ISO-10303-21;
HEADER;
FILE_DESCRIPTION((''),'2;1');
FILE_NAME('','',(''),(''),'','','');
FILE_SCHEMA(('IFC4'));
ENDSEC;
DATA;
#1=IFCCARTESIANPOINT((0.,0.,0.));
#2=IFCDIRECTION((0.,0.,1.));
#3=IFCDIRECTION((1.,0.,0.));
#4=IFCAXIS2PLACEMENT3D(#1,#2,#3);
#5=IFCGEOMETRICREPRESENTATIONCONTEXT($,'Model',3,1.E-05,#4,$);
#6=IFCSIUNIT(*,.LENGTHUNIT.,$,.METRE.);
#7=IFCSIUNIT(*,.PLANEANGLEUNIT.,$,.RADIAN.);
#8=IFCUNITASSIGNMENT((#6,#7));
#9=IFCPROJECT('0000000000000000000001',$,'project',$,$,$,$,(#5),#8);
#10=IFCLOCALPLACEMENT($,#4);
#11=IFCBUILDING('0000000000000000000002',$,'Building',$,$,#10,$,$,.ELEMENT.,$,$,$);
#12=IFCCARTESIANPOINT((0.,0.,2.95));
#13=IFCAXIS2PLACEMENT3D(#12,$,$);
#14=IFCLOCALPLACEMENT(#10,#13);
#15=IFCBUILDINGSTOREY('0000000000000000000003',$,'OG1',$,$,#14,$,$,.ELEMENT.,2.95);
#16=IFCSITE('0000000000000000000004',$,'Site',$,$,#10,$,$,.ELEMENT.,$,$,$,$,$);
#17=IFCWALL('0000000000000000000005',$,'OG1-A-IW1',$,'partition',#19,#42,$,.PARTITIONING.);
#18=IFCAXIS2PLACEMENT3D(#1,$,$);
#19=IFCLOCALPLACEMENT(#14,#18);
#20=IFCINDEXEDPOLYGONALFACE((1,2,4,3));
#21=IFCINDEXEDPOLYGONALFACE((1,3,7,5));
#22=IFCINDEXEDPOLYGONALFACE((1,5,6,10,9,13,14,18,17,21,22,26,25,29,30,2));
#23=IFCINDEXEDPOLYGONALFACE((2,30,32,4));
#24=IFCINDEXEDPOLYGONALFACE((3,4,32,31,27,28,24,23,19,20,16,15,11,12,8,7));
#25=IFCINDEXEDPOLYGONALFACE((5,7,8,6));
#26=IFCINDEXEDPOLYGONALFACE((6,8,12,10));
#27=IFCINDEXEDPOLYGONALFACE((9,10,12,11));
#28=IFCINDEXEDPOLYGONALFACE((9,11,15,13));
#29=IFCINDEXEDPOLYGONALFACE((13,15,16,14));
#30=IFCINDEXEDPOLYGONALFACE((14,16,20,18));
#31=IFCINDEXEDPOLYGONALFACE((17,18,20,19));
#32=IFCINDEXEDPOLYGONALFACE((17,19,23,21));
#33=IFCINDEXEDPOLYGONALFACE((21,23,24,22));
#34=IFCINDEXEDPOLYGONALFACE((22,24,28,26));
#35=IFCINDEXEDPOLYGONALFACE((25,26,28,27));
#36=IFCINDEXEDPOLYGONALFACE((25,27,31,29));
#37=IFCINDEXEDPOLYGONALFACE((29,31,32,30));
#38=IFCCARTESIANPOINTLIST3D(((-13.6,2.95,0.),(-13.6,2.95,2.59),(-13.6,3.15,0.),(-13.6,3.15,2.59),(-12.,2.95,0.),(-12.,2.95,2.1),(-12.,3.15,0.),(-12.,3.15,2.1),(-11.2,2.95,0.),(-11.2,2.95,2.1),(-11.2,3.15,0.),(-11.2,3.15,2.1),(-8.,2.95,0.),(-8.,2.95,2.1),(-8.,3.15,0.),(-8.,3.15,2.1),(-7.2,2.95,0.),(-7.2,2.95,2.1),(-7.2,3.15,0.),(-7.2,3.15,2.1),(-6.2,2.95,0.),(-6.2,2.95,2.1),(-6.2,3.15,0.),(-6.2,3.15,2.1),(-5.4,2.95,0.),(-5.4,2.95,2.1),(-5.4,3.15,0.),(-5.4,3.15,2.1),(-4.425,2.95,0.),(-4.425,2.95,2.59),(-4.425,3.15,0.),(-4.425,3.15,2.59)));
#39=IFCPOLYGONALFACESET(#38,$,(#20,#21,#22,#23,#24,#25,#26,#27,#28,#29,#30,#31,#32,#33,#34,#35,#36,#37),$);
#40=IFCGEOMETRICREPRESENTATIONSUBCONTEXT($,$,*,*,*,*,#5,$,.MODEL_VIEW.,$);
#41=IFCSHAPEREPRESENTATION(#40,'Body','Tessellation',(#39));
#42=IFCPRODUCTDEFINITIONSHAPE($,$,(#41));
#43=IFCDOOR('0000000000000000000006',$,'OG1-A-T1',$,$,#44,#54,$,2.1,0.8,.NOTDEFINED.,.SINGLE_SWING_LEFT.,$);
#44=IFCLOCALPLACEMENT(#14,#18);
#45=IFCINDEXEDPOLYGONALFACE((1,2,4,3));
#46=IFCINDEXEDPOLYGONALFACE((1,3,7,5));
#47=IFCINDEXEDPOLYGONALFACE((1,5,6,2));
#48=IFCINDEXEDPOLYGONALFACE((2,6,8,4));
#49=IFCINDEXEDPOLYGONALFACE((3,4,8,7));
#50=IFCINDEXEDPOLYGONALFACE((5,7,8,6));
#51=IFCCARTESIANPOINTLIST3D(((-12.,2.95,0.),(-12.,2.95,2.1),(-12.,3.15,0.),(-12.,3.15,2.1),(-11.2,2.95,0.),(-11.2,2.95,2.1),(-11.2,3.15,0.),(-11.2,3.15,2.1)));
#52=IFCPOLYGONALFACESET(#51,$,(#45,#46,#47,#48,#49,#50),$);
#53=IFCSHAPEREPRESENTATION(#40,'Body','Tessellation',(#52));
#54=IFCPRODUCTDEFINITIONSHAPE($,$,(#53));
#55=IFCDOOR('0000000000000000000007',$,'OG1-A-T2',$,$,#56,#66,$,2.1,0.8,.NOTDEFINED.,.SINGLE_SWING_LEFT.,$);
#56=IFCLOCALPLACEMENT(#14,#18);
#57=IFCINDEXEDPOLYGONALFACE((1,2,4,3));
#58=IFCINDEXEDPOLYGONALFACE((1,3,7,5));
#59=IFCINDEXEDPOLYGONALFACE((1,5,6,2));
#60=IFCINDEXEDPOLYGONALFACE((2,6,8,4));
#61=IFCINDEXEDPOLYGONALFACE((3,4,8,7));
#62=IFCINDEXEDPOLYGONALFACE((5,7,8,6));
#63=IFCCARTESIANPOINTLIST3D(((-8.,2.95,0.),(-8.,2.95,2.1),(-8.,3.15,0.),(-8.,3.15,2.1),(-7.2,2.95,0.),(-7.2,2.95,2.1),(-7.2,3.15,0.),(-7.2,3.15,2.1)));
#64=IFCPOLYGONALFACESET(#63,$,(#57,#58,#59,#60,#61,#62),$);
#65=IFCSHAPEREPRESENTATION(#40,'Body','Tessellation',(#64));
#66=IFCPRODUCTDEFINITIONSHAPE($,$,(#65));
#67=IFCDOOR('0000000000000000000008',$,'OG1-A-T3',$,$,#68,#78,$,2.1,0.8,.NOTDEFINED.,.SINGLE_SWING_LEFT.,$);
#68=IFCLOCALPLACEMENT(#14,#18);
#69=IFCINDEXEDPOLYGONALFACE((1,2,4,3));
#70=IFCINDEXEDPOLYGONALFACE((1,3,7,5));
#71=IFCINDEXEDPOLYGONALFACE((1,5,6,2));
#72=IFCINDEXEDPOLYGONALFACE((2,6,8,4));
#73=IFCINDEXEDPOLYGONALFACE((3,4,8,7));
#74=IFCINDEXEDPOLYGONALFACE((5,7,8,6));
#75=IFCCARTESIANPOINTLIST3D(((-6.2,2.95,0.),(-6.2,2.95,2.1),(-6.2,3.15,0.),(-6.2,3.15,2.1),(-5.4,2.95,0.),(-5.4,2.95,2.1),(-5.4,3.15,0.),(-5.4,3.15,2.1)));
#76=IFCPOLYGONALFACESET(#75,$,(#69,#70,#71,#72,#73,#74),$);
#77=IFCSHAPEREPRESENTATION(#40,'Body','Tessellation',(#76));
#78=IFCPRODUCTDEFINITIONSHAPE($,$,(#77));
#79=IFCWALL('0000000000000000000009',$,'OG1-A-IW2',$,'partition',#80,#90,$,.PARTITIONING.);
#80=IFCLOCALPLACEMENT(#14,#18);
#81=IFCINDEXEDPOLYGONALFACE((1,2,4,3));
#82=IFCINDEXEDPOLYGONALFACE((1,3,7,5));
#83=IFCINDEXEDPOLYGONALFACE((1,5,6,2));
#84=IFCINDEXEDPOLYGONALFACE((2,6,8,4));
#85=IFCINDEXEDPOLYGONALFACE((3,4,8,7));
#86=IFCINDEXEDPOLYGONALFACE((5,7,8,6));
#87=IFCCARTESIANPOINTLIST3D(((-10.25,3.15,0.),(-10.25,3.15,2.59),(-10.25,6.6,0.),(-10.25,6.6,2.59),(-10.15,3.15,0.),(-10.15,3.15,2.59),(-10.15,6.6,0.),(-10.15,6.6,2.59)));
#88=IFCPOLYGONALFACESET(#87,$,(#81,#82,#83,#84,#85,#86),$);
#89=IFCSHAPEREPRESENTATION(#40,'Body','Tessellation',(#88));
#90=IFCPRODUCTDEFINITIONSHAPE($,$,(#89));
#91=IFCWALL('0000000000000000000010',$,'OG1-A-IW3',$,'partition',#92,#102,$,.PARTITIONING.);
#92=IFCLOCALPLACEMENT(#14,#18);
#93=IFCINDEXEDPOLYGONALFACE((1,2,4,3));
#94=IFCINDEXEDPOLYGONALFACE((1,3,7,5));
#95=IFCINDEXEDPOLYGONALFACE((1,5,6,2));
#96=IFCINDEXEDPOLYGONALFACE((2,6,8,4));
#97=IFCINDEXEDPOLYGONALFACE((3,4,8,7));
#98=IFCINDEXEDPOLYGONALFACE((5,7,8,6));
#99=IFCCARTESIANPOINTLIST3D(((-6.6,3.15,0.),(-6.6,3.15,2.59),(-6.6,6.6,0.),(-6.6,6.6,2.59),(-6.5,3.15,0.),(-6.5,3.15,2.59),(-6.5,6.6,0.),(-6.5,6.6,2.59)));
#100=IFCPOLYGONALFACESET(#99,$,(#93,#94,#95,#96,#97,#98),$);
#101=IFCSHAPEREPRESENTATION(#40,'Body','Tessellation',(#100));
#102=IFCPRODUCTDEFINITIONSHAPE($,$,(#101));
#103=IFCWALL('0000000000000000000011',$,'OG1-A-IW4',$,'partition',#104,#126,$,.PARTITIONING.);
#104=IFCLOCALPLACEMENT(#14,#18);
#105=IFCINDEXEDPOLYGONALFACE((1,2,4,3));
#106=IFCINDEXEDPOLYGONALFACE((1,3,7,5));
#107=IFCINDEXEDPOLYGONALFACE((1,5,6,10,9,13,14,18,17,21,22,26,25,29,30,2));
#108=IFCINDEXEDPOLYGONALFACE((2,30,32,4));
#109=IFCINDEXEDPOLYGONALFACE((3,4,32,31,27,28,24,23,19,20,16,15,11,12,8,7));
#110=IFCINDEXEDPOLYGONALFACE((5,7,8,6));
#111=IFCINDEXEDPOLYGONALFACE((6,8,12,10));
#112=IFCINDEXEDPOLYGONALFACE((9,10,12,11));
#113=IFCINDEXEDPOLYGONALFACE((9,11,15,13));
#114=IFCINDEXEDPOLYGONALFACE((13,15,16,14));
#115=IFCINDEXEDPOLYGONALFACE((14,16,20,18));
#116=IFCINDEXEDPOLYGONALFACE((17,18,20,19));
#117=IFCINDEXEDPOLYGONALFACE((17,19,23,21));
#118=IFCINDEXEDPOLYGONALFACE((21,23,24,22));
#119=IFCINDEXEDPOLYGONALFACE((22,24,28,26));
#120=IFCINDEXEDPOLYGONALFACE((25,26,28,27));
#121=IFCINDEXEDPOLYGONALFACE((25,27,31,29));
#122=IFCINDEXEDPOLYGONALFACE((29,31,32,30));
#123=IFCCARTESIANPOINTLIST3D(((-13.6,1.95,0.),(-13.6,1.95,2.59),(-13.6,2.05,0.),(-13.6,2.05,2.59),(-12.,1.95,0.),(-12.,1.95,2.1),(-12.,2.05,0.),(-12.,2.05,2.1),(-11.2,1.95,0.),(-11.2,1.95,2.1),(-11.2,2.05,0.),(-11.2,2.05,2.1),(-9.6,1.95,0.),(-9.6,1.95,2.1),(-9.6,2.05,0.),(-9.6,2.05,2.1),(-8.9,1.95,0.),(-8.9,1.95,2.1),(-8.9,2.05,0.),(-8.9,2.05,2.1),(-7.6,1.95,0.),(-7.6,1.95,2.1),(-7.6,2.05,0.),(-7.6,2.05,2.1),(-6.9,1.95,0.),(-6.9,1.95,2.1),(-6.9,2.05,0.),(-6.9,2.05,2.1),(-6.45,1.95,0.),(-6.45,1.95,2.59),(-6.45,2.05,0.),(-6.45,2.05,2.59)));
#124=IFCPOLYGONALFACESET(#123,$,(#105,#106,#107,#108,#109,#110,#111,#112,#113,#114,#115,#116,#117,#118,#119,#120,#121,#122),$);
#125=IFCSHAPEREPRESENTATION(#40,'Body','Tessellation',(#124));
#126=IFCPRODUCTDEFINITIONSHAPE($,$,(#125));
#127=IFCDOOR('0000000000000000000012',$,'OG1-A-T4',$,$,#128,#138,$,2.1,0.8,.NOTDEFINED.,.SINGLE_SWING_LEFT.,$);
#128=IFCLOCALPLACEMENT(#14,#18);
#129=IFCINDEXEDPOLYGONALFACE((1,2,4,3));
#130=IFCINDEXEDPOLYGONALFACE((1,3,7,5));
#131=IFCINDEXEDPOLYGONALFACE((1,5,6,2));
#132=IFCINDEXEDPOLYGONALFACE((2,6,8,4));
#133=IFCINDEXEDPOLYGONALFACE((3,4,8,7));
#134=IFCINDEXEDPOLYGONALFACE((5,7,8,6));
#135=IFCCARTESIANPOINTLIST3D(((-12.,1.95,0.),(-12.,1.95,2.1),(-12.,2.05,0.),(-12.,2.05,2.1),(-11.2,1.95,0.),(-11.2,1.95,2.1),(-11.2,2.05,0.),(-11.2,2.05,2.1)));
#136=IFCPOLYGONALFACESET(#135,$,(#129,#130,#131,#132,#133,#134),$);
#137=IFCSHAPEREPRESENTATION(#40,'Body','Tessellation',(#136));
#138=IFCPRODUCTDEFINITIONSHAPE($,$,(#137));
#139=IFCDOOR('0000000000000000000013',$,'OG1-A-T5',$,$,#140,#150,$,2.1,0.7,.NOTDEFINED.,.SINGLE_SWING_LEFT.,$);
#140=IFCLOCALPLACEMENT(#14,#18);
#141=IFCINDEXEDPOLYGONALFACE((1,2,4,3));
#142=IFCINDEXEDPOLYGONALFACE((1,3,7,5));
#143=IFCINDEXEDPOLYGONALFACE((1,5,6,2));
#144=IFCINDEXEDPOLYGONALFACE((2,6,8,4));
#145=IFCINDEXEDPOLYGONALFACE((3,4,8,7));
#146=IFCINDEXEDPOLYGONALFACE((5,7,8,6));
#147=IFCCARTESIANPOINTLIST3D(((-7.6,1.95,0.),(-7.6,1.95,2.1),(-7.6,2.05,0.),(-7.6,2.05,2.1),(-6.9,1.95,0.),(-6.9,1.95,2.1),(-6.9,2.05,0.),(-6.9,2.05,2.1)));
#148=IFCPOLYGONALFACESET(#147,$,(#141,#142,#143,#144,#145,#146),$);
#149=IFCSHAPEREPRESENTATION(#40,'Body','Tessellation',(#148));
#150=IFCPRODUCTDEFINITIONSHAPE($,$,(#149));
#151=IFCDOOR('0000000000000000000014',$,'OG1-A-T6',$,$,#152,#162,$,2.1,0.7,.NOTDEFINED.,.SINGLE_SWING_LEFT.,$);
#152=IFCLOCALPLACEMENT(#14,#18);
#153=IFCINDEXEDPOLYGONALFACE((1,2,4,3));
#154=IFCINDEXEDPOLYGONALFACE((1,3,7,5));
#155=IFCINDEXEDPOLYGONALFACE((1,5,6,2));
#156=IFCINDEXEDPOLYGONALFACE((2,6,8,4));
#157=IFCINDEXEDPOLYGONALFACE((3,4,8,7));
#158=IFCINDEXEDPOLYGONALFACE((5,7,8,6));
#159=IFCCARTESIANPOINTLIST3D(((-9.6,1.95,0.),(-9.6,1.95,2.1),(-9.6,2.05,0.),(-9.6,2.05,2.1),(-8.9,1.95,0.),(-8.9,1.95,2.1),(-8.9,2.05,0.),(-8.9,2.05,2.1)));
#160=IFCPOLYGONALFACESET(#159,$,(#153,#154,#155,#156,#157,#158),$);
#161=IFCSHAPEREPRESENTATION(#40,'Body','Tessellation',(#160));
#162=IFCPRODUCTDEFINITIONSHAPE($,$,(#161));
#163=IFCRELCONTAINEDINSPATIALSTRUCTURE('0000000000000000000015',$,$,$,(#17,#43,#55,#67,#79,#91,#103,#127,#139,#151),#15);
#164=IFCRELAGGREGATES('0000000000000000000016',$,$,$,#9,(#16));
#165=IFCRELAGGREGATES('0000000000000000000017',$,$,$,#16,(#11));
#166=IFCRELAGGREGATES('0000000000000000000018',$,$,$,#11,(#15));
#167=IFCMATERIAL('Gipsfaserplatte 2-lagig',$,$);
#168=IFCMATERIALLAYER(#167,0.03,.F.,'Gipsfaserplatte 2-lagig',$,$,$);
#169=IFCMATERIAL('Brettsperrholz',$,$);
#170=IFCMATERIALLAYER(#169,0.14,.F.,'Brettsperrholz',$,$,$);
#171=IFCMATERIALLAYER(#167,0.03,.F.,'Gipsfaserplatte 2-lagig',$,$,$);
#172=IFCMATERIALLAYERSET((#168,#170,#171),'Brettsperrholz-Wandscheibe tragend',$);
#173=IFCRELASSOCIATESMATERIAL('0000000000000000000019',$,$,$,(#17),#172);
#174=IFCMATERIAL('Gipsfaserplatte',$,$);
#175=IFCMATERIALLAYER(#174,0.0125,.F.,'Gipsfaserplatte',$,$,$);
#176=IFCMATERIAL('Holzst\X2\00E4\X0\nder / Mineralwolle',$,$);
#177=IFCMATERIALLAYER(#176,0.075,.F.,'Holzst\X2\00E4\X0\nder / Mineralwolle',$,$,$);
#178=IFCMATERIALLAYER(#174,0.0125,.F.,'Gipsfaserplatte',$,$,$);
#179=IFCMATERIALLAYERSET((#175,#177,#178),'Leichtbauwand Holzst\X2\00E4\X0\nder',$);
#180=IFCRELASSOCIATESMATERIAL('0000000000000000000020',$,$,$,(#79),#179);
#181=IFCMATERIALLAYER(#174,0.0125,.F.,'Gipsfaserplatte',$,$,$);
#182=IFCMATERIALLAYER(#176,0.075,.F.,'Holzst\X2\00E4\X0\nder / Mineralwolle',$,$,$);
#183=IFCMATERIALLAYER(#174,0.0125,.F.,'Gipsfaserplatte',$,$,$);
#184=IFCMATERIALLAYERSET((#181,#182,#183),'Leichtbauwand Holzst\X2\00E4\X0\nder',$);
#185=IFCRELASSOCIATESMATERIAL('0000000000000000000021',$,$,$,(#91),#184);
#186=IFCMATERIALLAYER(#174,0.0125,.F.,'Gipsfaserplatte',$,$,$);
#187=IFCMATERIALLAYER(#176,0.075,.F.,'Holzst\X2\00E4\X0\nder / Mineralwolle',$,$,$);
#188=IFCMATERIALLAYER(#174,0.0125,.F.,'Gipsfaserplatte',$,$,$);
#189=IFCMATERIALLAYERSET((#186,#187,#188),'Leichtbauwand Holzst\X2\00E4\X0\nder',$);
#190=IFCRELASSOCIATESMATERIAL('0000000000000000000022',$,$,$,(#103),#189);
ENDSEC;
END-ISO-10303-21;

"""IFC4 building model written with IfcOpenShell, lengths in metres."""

from ifc_helpers import new_model, si_unit, frame, frame_2d, origin, origin_with_axes, place, context, subcontext, project, spatial, rectangle, extrude, material, layer, layer_set, element, fill, save


model = new_model("IFC4")

# Units and contexts
model_context = context("Model", 3, precision=1e-05, world=origin_with_axes())
sub_context = subcontext(model_context, None, None, "MODEL_VIEW")
ifc_project = project(units=[si_unit("LENGTHUNIT", "METRE"), si_unit("PLANEANGLEUNIT", "RADIAN")], contexts=[model_context])

# Site, building, storey
placement = place(None, origin_with_axes())
site = spatial("IfcSite", under=ifc_project, at=placement, Name="Site", CompositionType="ELEMENT")
building = spatial("IfcBuilding", under=site, at=placement, Name="Building", CompositionType="ELEMENT")
storey_placement = place(placement, frame((0.0, 0.0, 2.95)))
storey = spatial("IfcBuildingStorey", under=building, at=storey_placement, Name="OG1", CompositionType="ELEMENT", Elevation=2.95)

# Shared definitions
ifc_material_1 = material(Name="Gipsfaserplatte")

# Wall, openings, doors
ifc_material_2 = material(Name="Gipsfaserplatte 2-lagig")
ifc_layer_1 = layer(ifc_material_2, 0.03, ventilated=False, Name="Gipsfaserplatte 2-lagig")
ifc_material_3 = material(Name="Brettsperrholz")
ifc_layer_2 = layer(ifc_material_3, 0.14, ventilated=False, Name="Brettsperrholz")
ifc_layer_3 = layer(ifc_material_2, 0.03, ventilated=False, Name="Gipsfaserplatte 2-lagig")
ifc_layer_set_1 = layer_set([ifc_layer_1, ifc_layer_2, ifc_layer_3], Name="Brettsperrholz-Wandscheibe tragend")
wall_1_placement = place(storey_placement, frame((-13.6, 3.05, 0.0), z_axis=(0.0, 0.0, 1.0), x_axis=(1.0, 0.0, 0.0)))
wall_1 = element("IfcWall", 1, at=wall_1_placement, inside=storey, material=ifc_layer_set_1, Name="OG1-A-IW1", ObjectType="partition", PredefinedType="PARTITIONING", context=sub_context, shape_type="SweptSolid", body=[
    extrude(rectangle(XDim=9.175, YDim=0.2, at=frame_2d((4.5875, 0.0))), origin(), (0.0, 0.0, 1.0), 2.59),
])
opening_1_placement = place(wall_1_placement, frame((2.0, 0.15, 0.0), z_axis=(0.0, -1.0, 0.0), x_axis=(1.0, 0.0, 0.0)))
opening_1 = element("IfcOpeningElement", 2, at=opening_1_placement, cuts=wall_1, PredefinedType="OPENING", context=sub_context, shape_type="SweptSolid", body=[
    extrude(rectangle(XDim=0.8, YDim=2.1, at=frame_2d((0.0, 1.05))), origin(), (0.0, 0.0, 1.0), 0.3),
])
opening_2_placement = place(wall_1_placement, frame((6.0, 0.15, 0.0), z_axis=(0.0, -1.0, 0.0), x_axis=(1.0, 0.0, 0.0)))
opening_2 = element("IfcOpeningElement", 3, at=opening_2_placement, cuts=wall_1, PredefinedType="OPENING", context=sub_context, shape_type="SweptSolid", body=[
    extrude(rectangle(XDim=0.8, YDim=2.1, at=frame_2d((0.0, 1.05))), origin(), (0.0, 0.0, 1.0), 0.3),
])
opening_3_placement = place(wall_1_placement, frame((7.8, 0.15, 0.0), z_axis=(0.0, -1.0, 0.0), x_axis=(1.0, 0.0, 0.0)))
opening_3 = element("IfcOpeningElement", 4, at=opening_3_placement, cuts=wall_1, PredefinedType="OPENING", context=sub_context, shape_type="SweptSolid", body=[
    extrude(rectangle(XDim=0.8, YDim=2.1, at=frame_2d((0.0, 1.05))), origin(), (0.0, 0.0, 1.0), 0.3),
])
door_1_placement = place(wall_1_placement, frame((2.0, 0.1, 0.0), z_axis=(0.0, -1.0, 0.0), x_axis=(1.0, 0.0, 0.0)))
door_1 = element("IfcDoor", 5, at=door_1_placement, inside=storey, Name="OG1-A-T1", OperationType="SINGLE_SWING_LEFT", OverallHeight=2.1, OverallWidth=0.8, PredefinedType="NOTDEFINED", context=sub_context, shape_type="SweptSolid", body=[
    extrude(rectangle(XDim=0.8, YDim=2.1, at=frame_2d((0.0, 1.05))), origin(), (0.0, 0.0, 1.0), 0.2),
])
fill(opening_1, door_1)
door_2_placement = place(wall_1_placement, frame((6.0, 0.1, 0.0), z_axis=(0.0, -1.0, 0.0), x_axis=(1.0, 0.0, 0.0)))
door_2 = element("IfcDoor", 6, at=door_2_placement, inside=storey, Name="OG1-A-T2", OperationType="SINGLE_SWING_LEFT", OverallHeight=2.1, OverallWidth=0.8, PredefinedType="NOTDEFINED", context=sub_context, shape_type="SweptSolid", body=[
    extrude(rectangle(XDim=0.8, YDim=2.1, at=frame_2d((0.0, 1.05))), origin(), (0.0, 0.0, 1.0), 0.2),
])
fill(opening_2, door_2)
door_3_placement = place(wall_1_placement, frame((7.8, 0.1, 0.0), z_axis=(0.0, -1.0, 0.0), x_axis=(1.0, 0.0, 0.0)))
door_3 = element("IfcDoor", 7, at=door_3_placement, inside=storey, Name="OG1-A-T3", OperationType="SINGLE_SWING_LEFT", OverallHeight=2.1, OverallWidth=0.8, PredefinedType="NOTDEFINED", context=sub_context, shape_type="SweptSolid", body=[
    extrude(rectangle(XDim=0.8, YDim=2.1, at=frame_2d((0.0, 1.05))), origin(), (0.0, 0.0, 1.0), 0.2),
])
fill(opening_3, door_3)

# Walls
ifc_layer_4 = layer(ifc_material_1, 0.0125, ventilated=False, Name="Gipsfaserplatte")
ifc_material_4 = material(Name="Holzständer / Mineralwolle")
ifc_layer_5 = layer(ifc_material_4, 0.075, ventilated=False, Name="Holzständer / Mineralwolle")
ifc_layer_6 = layer(ifc_material_1, 0.0125, ventilated=False, Name="Gipsfaserplatte")
ifc_layer_set_2 = layer_set([ifc_layer_4, ifc_layer_5, ifc_layer_6], Name="Leichtbauwand Holzständer")
wall_2_placement = place(storey_placement, frame((-10.2, 3.15, 0.0), z_axis=(0.0, 0.0, 1.0), x_axis=(0.0, 1.0, 0.0)))
element("IfcWall", 8, at=wall_2_placement, inside=storey, material=ifc_layer_set_2, Name="OG1-A-IW2", ObjectType="partition", PredefinedType="PARTITIONING", context=sub_context, shape_type="SweptSolid", body=[
    extrude(rectangle(XDim=3.45, YDim=0.1, at=frame_2d((1.725, 0.0))), origin(), (0.0, 0.0, 1.0), 2.59),
])
ifc_layer_7 = layer(ifc_material_1, 0.0125, ventilated=False, Name="Gipsfaserplatte")
ifc_layer_8 = layer(ifc_material_4, 0.075, ventilated=False, Name="Holzständer / Mineralwolle")
ifc_layer_9 = layer(ifc_material_1, 0.0125, ventilated=False, Name="Gipsfaserplatte")
ifc_layer_set_3 = layer_set([ifc_layer_7, ifc_layer_8, ifc_layer_9], Name="Leichtbauwand Holzständer")
wall_3_placement = place(storey_placement, frame((-6.55, 3.15, 0.0), z_axis=(0.0, 0.0, 1.0), x_axis=(0.0, 1.0, 0.0)))
element("IfcWall", 9, at=wall_3_placement, inside=storey, material=ifc_layer_set_3, Name="OG1-A-IW3", ObjectType="partition", PredefinedType="PARTITIONING", context=sub_context, shape_type="SweptSolid", body=[
    extrude(rectangle(XDim=3.45, YDim=0.1, at=frame_2d((1.725, 0.0))), origin(), (0.0, 0.0, 1.0), 2.59),
])

# Wall, openings, doors
ifc_layer_10 = layer(ifc_material_1, 0.0125, ventilated=False, Name="Gipsfaserplatte")
ifc_layer_11 = layer(ifc_material_4, 0.075, ventilated=False, Name="Holzständer / Mineralwolle")
ifc_layer_12 = layer(ifc_material_1, 0.0125, ventilated=False, Name="Gipsfaserplatte")
ifc_layer_set_4 = layer_set([ifc_layer_10, ifc_layer_11, ifc_layer_12], Name="Leichtbauwand Holzständer")
wall_4_placement = place(storey_placement, frame((-13.6, 2.0, 0.0), z_axis=(0.0, 0.0, 1.0), x_axis=(1.0, 0.0, 0.0)))
wall_4 = element("IfcWall", 10, at=wall_4_placement, inside=storey, material=ifc_layer_set_4, Name="OG1-A-IW4", ObjectType="partition", PredefinedType="PARTITIONING", context=sub_context, shape_type="SweptSolid", body=[
    extrude(rectangle(XDim=7.15, YDim=0.1, at=frame_2d((3.575, 0.0))), origin(), (0.0, 0.0, 1.0), 2.59),
])
opening_4_placement = place(wall_4_placement, frame((2.0, 0.1, 0.0), z_axis=(0.0, -1.0, 0.0), x_axis=(1.0, 0.0, 0.0)))
opening_4 = element("IfcOpeningElement", 11, at=opening_4_placement, cuts=wall_4, PredefinedType="OPENING", context=sub_context, shape_type="SweptSolid", body=[
    extrude(rectangle(XDim=0.8, YDim=2.1, at=frame_2d((0.0, 1.05))), origin(), (0.0, 0.0, 1.0), 0.2),
])
opening_5_placement = place(wall_4_placement, frame((6.35, 0.1, 0.0), z_axis=(0.0, -1.0, 0.0), x_axis=(1.0, 0.0, 0.0)))
opening_5 = element("IfcOpeningElement", 12, at=opening_5_placement, cuts=wall_4, PredefinedType="OPENING", context=sub_context, shape_type="SweptSolid", body=[
    extrude(rectangle(XDim=0.7, YDim=2.1, at=frame_2d((0.0, 1.05))), origin(), (0.0, 0.0, 1.0), 0.2),
])
opening_6_placement = place(wall_4_placement, frame((4.35, 0.1, 0.0), z_axis=(0.0, -1.0, 0.0), x_axis=(1.0, 0.0, 0.0)))
opening_6 = element("IfcOpeningElement", 13, at=opening_6_placement, cuts=wall_4, PredefinedType="OPENING", context=sub_context, shape_type="SweptSolid", body=[
    extrude(rectangle(XDim=0.7, YDim=2.1, at=frame_2d((0.0, 1.05))), origin(), (0.0, 0.0, 1.0), 0.2),
])
door_4_placement = place(wall_4_placement, frame((2.0, 0.05, 0.0), z_axis=(0.0, -1.0, 0.0), x_axis=(1.0, 0.0, 0.0)))
door_4 = element("IfcDoor", 14, at=door_4_placement, inside=storey, Name="OG1-A-T4", OperationType="SINGLE_SWING_LEFT", OverallHeight=2.1, OverallWidth=0.8, PredefinedType="NOTDEFINED", context=sub_context, shape_type="SweptSolid", body=[
    extrude(rectangle(XDim=0.8, YDim=2.1, at=frame_2d((0.0, 1.05))), origin(), (0.0, 0.0, 1.0), 0.1),
])
fill(opening_4, door_4)
door_5_placement = place(wall_4_placement, frame((6.35, 0.05, 0.0), z_axis=(0.0, -1.0, 0.0), x_axis=(1.0, 0.0, 0.0)))
door_5 = element("IfcDoor", 15, at=door_5_placement, inside=storey, Name="OG1-A-T5", OperationType="SINGLE_SWING_LEFT", OverallHeight=2.1, OverallWidth=0.7, PredefinedType="NOTDEFINED", context=sub_context, shape_type="SweptSolid", body=[
    extrude(rectangle(XDim=0.7, YDim=2.1, at=frame_2d((0.0, 1.05))), origin(), (0.0, 0.0, 1.0), 0.1),
])
fill(opening_5, door_5)
door_6_placement = place(wall_4_placement, frame((4.35, 0.05, 0.0), z_axis=(0.0, -1.0, 0.0), x_axis=(1.0, 0.0, 0.0)))
door_6 = element("IfcDoor", 16, at=door_6_placement, inside=storey, Name="OG1-A-T6", OperationType="SINGLE_SWING_LEFT", OverallHeight=2.1, OverallWidth=0.7, PredefinedType="NOTDEFINED", context=sub_context, shape_type="SweptSolid", body=[
    extrude(rectangle(XDim=0.7, YDim=2.1, at=frame_2d((0.0, 1.05))), origin(), (0.0, 0.0, 1.0), 0.1),
])
fill(opening_6, door_6)

save(model, "model.ifc")
